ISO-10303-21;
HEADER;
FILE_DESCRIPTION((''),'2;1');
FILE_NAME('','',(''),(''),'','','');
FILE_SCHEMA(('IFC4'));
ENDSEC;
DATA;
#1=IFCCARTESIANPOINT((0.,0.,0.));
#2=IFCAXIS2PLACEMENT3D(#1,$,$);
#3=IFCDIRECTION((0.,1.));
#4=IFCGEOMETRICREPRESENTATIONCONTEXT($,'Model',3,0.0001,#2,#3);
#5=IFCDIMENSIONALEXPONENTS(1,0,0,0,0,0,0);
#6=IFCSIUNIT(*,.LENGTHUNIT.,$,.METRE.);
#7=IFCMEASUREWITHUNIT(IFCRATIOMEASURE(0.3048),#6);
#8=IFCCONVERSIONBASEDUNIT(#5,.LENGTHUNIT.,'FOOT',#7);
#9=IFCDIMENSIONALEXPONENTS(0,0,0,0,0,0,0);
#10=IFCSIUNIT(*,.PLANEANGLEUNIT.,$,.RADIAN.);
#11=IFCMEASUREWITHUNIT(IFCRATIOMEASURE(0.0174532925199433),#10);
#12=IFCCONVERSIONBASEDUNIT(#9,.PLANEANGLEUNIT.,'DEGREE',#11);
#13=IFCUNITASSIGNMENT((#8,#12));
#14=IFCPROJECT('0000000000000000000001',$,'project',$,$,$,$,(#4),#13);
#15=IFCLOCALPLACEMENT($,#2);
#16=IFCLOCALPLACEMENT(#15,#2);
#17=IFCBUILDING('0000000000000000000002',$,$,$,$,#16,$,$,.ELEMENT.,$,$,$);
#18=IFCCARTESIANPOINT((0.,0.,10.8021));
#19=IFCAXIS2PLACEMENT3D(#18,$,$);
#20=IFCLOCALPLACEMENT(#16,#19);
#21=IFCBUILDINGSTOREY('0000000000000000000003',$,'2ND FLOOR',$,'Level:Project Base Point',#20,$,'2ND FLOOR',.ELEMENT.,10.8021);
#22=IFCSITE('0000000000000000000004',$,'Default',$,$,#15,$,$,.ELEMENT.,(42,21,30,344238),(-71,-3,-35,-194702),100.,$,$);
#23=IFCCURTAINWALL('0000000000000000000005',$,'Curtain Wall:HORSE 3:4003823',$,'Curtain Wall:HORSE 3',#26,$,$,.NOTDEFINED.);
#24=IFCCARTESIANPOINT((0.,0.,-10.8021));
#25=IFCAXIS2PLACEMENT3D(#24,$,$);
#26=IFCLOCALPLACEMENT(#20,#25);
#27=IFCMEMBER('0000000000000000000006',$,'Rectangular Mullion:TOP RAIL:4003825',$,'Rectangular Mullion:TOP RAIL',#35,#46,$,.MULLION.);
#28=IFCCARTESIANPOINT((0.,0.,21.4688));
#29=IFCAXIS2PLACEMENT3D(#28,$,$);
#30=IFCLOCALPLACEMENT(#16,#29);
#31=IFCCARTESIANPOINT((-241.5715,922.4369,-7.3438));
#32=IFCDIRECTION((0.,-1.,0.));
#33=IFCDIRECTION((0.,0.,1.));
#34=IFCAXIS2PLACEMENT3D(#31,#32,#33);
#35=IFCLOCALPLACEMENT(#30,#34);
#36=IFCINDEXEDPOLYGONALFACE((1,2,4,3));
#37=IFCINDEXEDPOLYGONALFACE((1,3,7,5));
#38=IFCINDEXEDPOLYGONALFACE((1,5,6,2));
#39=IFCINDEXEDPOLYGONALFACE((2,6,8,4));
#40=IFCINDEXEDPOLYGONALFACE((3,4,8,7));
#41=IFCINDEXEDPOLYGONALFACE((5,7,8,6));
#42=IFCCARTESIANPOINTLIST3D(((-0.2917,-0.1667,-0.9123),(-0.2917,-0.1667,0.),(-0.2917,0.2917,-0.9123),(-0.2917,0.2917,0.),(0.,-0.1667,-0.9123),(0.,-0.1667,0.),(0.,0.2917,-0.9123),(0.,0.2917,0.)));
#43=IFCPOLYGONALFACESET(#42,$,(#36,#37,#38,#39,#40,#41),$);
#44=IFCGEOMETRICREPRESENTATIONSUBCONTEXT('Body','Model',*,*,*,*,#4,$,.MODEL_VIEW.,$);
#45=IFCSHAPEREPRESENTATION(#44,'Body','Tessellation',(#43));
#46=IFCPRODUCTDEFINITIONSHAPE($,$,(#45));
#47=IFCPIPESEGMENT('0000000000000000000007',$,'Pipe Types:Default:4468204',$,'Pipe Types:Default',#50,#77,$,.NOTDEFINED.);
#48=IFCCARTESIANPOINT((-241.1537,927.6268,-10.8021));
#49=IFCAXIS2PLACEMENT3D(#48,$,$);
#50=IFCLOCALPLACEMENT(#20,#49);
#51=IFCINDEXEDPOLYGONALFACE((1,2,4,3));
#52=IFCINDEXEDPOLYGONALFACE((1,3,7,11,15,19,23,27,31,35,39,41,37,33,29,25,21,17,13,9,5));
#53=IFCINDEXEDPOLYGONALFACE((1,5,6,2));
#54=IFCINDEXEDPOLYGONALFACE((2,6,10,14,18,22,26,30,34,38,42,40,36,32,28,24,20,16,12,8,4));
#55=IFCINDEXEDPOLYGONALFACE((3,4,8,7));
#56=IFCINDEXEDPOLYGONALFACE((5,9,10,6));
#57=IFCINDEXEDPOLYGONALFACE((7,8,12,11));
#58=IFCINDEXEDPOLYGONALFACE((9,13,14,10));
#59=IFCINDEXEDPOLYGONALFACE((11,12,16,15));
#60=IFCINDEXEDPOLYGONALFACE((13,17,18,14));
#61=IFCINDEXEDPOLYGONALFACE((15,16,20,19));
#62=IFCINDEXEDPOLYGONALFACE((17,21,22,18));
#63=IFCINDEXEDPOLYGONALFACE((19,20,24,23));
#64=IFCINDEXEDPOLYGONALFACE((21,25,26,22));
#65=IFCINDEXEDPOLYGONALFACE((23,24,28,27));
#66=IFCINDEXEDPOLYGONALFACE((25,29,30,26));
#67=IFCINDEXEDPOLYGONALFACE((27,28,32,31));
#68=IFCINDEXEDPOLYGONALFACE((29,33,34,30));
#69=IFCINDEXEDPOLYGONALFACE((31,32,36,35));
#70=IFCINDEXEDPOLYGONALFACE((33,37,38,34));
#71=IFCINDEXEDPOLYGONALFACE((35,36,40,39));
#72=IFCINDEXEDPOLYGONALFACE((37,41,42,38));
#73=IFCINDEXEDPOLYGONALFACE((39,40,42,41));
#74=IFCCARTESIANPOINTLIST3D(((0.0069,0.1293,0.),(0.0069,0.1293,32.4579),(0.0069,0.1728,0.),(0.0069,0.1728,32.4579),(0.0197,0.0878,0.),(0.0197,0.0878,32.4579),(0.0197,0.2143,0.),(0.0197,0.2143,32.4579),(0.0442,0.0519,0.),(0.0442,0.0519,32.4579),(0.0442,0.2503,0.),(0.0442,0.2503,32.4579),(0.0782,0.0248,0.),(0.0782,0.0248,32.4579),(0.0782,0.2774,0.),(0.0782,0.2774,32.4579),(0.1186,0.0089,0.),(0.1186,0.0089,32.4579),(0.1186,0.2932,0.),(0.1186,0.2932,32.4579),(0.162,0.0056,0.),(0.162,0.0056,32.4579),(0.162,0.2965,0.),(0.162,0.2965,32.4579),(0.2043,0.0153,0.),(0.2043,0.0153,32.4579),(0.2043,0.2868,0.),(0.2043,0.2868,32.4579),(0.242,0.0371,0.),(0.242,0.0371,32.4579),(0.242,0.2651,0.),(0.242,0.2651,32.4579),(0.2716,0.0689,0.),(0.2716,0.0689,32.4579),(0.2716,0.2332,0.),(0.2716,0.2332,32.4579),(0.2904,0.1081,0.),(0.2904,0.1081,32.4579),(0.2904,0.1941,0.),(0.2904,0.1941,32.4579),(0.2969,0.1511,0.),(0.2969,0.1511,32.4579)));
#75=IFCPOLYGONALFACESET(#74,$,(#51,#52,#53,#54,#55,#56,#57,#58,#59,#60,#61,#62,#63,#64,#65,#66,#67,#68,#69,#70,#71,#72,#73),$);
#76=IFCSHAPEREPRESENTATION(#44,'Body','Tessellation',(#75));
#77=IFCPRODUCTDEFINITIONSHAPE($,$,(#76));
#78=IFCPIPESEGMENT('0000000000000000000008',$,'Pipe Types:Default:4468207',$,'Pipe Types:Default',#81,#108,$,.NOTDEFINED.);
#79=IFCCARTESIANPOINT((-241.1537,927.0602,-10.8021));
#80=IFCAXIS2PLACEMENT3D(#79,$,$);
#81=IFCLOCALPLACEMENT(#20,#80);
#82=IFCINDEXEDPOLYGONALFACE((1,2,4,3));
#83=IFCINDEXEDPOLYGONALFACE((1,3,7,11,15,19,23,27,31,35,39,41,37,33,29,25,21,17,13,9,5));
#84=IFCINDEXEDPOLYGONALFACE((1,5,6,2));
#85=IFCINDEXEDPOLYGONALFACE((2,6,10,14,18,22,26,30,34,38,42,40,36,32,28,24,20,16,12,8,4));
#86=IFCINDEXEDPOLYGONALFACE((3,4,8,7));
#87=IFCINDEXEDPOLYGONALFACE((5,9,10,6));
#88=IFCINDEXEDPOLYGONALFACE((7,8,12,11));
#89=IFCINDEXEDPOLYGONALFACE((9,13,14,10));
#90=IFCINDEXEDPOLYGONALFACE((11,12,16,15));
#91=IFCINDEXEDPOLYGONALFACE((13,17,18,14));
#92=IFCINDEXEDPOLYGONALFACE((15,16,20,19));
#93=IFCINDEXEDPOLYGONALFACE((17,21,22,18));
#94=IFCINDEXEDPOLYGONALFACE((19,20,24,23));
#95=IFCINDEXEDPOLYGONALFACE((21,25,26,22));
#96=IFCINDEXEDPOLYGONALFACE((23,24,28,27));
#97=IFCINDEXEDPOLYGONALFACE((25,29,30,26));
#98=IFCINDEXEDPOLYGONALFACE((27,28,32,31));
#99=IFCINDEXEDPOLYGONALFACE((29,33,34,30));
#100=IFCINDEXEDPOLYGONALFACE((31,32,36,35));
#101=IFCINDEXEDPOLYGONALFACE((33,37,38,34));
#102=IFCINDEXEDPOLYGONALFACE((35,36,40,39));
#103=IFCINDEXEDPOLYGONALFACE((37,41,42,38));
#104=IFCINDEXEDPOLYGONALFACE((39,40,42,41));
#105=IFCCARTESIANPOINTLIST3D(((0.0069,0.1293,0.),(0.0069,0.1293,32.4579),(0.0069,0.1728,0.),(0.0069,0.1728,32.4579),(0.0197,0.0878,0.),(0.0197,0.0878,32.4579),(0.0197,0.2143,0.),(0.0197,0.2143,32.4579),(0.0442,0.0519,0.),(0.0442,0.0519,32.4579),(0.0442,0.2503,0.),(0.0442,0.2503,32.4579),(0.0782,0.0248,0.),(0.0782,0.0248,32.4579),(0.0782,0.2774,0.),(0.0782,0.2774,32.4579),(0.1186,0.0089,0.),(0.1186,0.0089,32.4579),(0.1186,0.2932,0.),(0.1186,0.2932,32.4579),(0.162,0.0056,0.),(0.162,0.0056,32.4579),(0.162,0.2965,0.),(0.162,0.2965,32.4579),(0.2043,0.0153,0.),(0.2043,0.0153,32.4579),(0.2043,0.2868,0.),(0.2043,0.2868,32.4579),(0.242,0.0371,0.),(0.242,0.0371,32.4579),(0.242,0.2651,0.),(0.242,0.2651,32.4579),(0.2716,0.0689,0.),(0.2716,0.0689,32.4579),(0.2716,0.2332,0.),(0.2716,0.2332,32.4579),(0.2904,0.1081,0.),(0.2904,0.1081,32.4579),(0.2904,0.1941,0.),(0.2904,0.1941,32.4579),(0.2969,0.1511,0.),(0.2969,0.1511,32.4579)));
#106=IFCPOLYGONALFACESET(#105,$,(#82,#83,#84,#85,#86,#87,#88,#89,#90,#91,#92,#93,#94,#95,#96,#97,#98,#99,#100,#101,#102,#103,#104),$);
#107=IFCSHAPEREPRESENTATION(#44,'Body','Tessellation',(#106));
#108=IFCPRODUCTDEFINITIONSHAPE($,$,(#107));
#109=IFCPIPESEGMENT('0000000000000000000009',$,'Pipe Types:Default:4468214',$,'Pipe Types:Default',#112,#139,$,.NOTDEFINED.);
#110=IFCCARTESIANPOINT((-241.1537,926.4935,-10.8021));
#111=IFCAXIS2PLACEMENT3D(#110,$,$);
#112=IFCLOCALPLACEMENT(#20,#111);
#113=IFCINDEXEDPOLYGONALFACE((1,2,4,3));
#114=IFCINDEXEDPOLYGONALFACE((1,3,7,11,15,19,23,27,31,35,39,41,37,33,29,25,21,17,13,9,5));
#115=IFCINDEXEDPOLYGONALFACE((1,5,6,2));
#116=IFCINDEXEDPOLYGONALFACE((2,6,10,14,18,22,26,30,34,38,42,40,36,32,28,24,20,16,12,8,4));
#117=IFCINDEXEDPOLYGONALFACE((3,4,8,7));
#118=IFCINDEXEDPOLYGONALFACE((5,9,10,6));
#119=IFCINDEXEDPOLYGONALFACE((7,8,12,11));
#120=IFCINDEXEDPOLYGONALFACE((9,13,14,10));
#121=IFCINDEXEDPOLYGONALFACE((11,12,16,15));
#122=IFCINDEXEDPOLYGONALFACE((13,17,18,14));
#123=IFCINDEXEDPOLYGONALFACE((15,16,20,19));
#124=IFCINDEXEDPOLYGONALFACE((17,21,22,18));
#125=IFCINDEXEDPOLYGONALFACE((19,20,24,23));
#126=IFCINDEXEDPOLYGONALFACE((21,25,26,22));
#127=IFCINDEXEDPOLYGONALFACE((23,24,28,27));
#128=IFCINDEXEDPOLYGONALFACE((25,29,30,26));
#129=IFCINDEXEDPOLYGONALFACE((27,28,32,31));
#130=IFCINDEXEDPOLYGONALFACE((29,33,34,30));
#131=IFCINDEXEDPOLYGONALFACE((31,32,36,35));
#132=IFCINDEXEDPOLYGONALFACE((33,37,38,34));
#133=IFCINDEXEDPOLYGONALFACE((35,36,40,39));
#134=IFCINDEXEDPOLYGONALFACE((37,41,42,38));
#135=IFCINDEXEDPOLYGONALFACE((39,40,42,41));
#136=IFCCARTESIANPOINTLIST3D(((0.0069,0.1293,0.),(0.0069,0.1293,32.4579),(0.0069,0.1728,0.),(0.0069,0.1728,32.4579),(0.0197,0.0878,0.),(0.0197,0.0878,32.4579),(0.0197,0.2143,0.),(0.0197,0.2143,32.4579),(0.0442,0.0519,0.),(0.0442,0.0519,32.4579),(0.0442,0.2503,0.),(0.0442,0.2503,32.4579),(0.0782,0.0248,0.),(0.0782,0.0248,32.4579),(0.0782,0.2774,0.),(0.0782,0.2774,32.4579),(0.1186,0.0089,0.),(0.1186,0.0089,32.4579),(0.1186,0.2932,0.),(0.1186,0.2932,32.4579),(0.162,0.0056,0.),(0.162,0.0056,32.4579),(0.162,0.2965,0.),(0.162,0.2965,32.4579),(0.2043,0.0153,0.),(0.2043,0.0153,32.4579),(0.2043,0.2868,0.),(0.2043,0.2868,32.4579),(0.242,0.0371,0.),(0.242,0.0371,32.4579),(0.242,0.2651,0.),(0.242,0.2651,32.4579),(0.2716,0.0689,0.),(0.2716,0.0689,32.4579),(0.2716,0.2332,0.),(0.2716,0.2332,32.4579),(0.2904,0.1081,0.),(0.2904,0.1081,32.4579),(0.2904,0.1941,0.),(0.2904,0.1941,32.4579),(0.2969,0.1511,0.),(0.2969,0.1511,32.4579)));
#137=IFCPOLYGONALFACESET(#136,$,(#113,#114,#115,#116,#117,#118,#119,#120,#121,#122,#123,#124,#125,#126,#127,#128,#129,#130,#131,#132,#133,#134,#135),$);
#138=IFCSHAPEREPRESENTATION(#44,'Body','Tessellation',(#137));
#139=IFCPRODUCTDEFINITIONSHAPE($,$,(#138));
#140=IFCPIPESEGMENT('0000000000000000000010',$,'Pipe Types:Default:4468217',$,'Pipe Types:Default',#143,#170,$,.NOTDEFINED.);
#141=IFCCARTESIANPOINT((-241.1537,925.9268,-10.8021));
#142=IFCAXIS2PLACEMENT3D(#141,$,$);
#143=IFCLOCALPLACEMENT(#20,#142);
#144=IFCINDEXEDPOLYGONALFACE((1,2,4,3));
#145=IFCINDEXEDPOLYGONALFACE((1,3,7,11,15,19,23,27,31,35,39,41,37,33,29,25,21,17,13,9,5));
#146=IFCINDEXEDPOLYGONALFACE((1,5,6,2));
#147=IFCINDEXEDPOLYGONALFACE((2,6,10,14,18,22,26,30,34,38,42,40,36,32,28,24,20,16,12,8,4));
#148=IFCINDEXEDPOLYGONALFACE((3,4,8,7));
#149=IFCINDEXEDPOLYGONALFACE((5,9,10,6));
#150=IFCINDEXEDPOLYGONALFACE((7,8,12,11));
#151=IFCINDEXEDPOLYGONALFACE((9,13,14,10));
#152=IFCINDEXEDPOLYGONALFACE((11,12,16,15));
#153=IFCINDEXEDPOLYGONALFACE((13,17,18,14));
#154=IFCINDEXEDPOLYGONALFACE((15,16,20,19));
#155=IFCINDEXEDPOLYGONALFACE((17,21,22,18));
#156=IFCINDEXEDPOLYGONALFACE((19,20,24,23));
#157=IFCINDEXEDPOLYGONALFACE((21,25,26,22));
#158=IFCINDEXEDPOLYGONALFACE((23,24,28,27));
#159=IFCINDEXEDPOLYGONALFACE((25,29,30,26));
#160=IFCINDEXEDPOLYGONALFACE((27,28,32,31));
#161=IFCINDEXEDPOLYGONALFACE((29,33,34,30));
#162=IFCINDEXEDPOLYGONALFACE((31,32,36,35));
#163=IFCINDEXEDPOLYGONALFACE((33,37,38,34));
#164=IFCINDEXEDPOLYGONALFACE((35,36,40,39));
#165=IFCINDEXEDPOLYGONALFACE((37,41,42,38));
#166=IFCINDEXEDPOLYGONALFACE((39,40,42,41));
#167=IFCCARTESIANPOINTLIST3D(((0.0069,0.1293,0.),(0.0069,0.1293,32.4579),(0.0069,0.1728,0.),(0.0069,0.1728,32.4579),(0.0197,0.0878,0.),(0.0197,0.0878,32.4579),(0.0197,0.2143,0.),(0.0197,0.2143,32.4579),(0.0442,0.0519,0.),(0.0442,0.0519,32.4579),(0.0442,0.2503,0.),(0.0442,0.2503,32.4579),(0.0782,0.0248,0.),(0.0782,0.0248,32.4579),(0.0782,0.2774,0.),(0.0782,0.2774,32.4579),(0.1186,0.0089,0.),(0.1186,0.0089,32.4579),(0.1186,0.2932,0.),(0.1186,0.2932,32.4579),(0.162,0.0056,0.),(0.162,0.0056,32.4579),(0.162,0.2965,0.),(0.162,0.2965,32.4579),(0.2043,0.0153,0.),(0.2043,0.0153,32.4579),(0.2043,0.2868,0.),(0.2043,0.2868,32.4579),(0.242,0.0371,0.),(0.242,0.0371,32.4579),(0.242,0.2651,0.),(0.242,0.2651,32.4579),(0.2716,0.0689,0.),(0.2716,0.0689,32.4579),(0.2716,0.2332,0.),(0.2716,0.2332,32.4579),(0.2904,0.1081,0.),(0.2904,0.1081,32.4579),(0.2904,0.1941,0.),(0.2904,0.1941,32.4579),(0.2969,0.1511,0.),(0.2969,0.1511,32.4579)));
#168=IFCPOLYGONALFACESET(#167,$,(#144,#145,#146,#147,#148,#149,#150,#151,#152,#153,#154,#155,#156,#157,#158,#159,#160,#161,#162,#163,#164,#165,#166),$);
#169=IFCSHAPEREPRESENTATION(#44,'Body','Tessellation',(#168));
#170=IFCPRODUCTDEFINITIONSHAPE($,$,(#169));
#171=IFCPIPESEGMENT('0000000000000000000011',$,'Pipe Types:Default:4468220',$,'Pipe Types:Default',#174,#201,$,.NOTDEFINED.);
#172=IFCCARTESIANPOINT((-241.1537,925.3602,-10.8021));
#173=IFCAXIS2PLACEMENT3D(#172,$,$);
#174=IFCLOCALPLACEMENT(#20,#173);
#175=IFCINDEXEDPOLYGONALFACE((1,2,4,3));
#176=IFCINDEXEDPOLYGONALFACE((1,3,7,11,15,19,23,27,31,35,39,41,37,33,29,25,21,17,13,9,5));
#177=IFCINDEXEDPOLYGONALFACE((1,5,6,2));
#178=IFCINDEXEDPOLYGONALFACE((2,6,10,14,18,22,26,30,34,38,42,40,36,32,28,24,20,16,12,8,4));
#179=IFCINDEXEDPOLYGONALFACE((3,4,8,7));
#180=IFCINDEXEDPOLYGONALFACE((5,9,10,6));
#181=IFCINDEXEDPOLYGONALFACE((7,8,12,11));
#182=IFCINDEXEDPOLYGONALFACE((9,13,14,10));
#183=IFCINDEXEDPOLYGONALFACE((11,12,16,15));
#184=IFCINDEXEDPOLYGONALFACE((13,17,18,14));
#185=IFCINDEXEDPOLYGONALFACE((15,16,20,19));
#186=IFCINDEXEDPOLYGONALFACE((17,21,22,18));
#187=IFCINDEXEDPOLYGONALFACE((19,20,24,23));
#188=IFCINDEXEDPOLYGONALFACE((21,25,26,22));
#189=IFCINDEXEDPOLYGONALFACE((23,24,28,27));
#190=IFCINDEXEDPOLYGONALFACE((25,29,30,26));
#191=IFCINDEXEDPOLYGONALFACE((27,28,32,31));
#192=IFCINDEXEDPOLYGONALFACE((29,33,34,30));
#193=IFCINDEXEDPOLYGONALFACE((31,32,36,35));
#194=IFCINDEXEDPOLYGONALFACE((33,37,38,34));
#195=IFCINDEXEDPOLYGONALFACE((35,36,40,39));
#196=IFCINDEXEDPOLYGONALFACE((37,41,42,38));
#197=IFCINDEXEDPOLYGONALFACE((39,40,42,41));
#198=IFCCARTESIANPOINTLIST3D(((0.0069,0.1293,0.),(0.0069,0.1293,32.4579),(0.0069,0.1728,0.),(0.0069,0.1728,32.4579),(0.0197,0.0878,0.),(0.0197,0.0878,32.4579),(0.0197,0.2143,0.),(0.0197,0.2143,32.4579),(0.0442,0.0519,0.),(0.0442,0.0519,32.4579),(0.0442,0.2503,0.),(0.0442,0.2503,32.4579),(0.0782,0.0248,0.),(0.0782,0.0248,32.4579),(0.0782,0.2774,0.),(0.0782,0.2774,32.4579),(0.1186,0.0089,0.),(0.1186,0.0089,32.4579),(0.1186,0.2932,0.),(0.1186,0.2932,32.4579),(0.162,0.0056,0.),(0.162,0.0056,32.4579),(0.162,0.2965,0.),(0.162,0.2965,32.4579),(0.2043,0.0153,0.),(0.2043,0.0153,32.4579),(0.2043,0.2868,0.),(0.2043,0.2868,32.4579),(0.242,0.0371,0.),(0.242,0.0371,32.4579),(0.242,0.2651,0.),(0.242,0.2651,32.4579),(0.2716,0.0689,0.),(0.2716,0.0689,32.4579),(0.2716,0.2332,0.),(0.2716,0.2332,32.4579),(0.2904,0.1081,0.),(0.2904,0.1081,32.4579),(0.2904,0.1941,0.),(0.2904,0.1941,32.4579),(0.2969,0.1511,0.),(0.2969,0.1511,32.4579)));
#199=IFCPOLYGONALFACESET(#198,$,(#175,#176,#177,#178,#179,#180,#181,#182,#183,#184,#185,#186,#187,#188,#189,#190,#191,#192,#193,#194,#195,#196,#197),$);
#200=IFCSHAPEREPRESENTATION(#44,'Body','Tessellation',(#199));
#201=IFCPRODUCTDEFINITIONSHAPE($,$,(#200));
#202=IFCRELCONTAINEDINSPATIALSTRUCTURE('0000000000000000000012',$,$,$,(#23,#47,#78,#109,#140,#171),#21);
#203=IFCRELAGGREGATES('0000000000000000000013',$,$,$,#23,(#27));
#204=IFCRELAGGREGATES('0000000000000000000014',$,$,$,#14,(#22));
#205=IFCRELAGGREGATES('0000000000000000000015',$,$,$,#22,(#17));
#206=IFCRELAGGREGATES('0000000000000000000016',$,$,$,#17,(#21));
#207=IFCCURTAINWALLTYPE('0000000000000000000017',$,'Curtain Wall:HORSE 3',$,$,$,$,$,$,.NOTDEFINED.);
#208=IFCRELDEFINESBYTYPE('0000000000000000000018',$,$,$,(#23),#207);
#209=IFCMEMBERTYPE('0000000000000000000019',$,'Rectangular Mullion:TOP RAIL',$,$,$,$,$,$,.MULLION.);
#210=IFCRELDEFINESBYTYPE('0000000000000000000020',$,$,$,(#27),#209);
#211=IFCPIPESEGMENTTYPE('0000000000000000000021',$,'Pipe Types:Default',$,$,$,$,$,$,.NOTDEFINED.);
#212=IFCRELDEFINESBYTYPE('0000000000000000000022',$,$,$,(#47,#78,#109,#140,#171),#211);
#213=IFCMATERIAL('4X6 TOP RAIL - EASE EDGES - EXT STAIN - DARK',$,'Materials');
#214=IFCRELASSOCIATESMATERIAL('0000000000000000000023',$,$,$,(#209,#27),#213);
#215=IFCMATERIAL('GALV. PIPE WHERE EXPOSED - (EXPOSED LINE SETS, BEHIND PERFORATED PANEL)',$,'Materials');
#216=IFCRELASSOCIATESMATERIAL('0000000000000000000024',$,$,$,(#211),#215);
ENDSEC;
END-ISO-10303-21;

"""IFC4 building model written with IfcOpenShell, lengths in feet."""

from ifc_helpers import new_model, entity, si_unit, converted_unit, direction, frame, frame_2d, origin, origin_2d_with_axis, place, context, subcontext, project, spatial, rectangle, circle, extrude, source, transform, mapped, material, material_profile, profile_set, profile_usage, type_object, type_shapes, element, aggregate, save


model = new_model("IFC4")

# Units and contexts
model_context = context("Model", 3, precision=0.0001, world=origin(), true_north=direction((0.0, 1.0)))
body_context = subcontext(model_context, "Body", "Model", "MODEL_VIEW")
ifc_project = project(units=[converted_unit("LENGTHUNIT", "FOOT", entity("IfcRatioMeasure", 0.3048), si_unit("LENGTHUNIT", "METRE"), dimensions=[1, 0, 0, 0, 0, 0, 0]), converted_unit("PLANEANGLEUNIT", "DEGREE", entity("IfcRatioMeasure", 0.0174532925199433), si_unit("PLANEANGLEUNIT", "RADIAN"), dimensions=[0, 0, 0, 0, 0, 0, 0])], contexts=[model_context])

# Site, building, storey
site_placement = place(None, origin())
site = spatial("IfcSite", under=ifc_project, at=site_placement, Name="Default", CompositionType="ELEMENT", RefLatitude=(42, 21, 30, 344238), RefLongitude=(-71, -3, -35, -194702), RefElevation=100.0)
building_placement = place(site_placement, origin())
building = spatial("IfcBuilding", under=site, at=building_placement, CompositionType="ELEMENT")
storey_placement = place(building_placement, frame((0.0, 0.0, 10.8021)))
storey = spatial("IfcBuildingStorey", under=building, at=storey_placement, Name="2ND FLOOR", ObjectType="Level:Project Base Point", LongName="2ND FLOOR", CompositionType="ELEMENT", Elevation=10.8021)

# Curtain wall, member
curtain_wall_type = type_object("IfcCurtainWallType", Name="Curtain Wall:HORSE 3", PredefinedType="NOTDEFINED")
curtain_wall_1_placement = place(storey_placement, frame((0.0, 0.0, -10.8021)))
curtain_wall_1 = element("IfcCurtainWall", 1, at=curtain_wall_1_placement, inside=storey, type_object=curtain_wall_type, Name="Curtain Wall:HORSE 3:4003823", ObjectType="Curtain Wall:HORSE 3", PredefinedType="NOTDEFINED")
ifc_material_1 = material(Name="4X6 TOP RAIL - EASE EDGES - EXT STAIN - DARK", Category="Materials")
ifc_material_profile_1 = material_profile(ifc_material_1, rectangle(XDim=0.4583, YDim=0.2917, at=origin_2d_with_axis()), Name="TOP RAIL")
ifc_profile_set_1 = profile_set([ifc_material_profile_1], Name="TOP RAIL")
ifc_profile_usage_1 = profile_usage(ifc_profile_set_1)
member_type_1 = type_object("IfcMemberType", Name="Rectangular Mullion:TOP RAIL", PredefinedType="MULLION", material=ifc_profile_set_1)
shared_shape_1 = source(origin(), body_context, "Body", "SweptSolid", [
    extrude(rectangle(XDim=0.4583, YDim=0.2917, at=origin_2d_with_axis()), frame((-0.1458, 0.0625, -0.9123), z_axis=(0.0, 0.0, 1.0), x_axis=(0.0, -1.0, 0.0)), (0.0, 0.0, 1.0), 0.9123),
])
type_shapes(member_type_1, [shared_shape_1])
placement = place(building_placement, frame((0.0, 0.0, 21.4688)))
member_1_placement = place(placement, frame((-241.5715, 922.4369, -7.3438), z_axis=(0.0, -1.0, 0.0), x_axis=(0.0, 0.0, 1.0)))
member_1 = element("IfcMember", 2, at=member_1_placement, type_object=member_type_1, material=ifc_profile_usage_1, Name="Rectangular Mullion:TOP RAIL:4003825", ObjectType="Rectangular Mullion:TOP RAIL", PredefinedType="MULLION", context=body_context, shape_type="MappedRepresentation", body=[
    mapped(shared_shape_1, transform((0.0, 0.0, 0.0), scale=1.0)),
])

aggregate(curtain_wall_1, [member_1])

# Pipe segments
ifc_material_2 = material(Name="GALV. PIPE WHERE EXPOSED - (EXPOSED LINE SETS, BEHIND PERFORATED PANEL)", Category="Materials")
pipe_segment_type = type_object("IfcPipeSegmentType", Name="Pipe Types:Default", PredefinedType="NOTDEFINED", material=ifc_material_2)
pipe_segment_1_placement = place(storey_placement, frame((-241.1537, 927.6268, -10.8021)))
element("IfcPipeSegment", 3, at=pipe_segment_1_placement, inside=storey, type_object=pipe_segment_type, Name="Pipe Types:Default:4468204", ObjectType="Pipe Types:Default", PredefinedType="NOTDEFINED", context=body_context, shape_type="SweptSolid", body=[
    extrude(circle(Radius=0.1458, at=frame_2d((0.0, 0.0), x_axis=(1.0, 0.0))), frame((0.1511, 0.1511, 0.0)), (0.0, 0.0, 1.0), 32.4579),
])
for number, where, name in (
    (4, (-241.1537, 927.0602, -10.8021), "Pipe Types:Default:4468207"),
    (5, (-241.1537, 926.4935, -10.8021), "Pipe Types:Default:4468214"),
):
    element("IfcPipeSegment", number, at=place(storey_placement, frame(where)), inside=storey, type_object=pipe_segment_type, Name=name, ObjectType="Pipe Types:Default", PredefinedType="NOTDEFINED", context=body_context, shape_type="SweptSolid", body=[
        extrude(circle(Radius=0.1458, at=origin_2d_with_axis()), frame((0.1511, 0.1511, 0.0)), (0.0, 0.0, 1.0), 32.4579),
    ])
pipe_segment_2_placement = place(storey_placement, frame((-241.1537, 925.9268, -10.8021)))
element("IfcPipeSegment", 6, at=pipe_segment_2_placement, inside=storey, type_object=pipe_segment_type, Name="Pipe Types:Default:4468217", ObjectType="Pipe Types:Default", PredefinedType="NOTDEFINED", context=body_context, shape_type="SweptSolid", body=[
    extrude(circle(Radius=0.1458, at=frame_2d((0.0, 0.0), x_axis=(1.0, 0.0))), frame((0.1511, 0.1511, 0.0)), (0.0, 0.0, 1.0), 32.4579),
])
for number, where, name in (
    (7, (-241.1537, 925.3602, -10.8021), "Pipe Types:Default:4468220"),
):
    element("IfcPipeSegment", number, at=place(storey_placement, frame(where)), inside=storey, type_object=pipe_segment_type, Name=name, ObjectType="Pipe Types:Default", PredefinedType="NOTDEFINED", context=body_context, shape_type="SweptSolid", body=[
        extrude(circle(Radius=0.1458, at=origin_2d_with_axis()), frame((0.1511, 0.1511, 0.0)), (0.0, 0.0, 1.0), 32.4579),
    ])

save(model, "model.ifc")
